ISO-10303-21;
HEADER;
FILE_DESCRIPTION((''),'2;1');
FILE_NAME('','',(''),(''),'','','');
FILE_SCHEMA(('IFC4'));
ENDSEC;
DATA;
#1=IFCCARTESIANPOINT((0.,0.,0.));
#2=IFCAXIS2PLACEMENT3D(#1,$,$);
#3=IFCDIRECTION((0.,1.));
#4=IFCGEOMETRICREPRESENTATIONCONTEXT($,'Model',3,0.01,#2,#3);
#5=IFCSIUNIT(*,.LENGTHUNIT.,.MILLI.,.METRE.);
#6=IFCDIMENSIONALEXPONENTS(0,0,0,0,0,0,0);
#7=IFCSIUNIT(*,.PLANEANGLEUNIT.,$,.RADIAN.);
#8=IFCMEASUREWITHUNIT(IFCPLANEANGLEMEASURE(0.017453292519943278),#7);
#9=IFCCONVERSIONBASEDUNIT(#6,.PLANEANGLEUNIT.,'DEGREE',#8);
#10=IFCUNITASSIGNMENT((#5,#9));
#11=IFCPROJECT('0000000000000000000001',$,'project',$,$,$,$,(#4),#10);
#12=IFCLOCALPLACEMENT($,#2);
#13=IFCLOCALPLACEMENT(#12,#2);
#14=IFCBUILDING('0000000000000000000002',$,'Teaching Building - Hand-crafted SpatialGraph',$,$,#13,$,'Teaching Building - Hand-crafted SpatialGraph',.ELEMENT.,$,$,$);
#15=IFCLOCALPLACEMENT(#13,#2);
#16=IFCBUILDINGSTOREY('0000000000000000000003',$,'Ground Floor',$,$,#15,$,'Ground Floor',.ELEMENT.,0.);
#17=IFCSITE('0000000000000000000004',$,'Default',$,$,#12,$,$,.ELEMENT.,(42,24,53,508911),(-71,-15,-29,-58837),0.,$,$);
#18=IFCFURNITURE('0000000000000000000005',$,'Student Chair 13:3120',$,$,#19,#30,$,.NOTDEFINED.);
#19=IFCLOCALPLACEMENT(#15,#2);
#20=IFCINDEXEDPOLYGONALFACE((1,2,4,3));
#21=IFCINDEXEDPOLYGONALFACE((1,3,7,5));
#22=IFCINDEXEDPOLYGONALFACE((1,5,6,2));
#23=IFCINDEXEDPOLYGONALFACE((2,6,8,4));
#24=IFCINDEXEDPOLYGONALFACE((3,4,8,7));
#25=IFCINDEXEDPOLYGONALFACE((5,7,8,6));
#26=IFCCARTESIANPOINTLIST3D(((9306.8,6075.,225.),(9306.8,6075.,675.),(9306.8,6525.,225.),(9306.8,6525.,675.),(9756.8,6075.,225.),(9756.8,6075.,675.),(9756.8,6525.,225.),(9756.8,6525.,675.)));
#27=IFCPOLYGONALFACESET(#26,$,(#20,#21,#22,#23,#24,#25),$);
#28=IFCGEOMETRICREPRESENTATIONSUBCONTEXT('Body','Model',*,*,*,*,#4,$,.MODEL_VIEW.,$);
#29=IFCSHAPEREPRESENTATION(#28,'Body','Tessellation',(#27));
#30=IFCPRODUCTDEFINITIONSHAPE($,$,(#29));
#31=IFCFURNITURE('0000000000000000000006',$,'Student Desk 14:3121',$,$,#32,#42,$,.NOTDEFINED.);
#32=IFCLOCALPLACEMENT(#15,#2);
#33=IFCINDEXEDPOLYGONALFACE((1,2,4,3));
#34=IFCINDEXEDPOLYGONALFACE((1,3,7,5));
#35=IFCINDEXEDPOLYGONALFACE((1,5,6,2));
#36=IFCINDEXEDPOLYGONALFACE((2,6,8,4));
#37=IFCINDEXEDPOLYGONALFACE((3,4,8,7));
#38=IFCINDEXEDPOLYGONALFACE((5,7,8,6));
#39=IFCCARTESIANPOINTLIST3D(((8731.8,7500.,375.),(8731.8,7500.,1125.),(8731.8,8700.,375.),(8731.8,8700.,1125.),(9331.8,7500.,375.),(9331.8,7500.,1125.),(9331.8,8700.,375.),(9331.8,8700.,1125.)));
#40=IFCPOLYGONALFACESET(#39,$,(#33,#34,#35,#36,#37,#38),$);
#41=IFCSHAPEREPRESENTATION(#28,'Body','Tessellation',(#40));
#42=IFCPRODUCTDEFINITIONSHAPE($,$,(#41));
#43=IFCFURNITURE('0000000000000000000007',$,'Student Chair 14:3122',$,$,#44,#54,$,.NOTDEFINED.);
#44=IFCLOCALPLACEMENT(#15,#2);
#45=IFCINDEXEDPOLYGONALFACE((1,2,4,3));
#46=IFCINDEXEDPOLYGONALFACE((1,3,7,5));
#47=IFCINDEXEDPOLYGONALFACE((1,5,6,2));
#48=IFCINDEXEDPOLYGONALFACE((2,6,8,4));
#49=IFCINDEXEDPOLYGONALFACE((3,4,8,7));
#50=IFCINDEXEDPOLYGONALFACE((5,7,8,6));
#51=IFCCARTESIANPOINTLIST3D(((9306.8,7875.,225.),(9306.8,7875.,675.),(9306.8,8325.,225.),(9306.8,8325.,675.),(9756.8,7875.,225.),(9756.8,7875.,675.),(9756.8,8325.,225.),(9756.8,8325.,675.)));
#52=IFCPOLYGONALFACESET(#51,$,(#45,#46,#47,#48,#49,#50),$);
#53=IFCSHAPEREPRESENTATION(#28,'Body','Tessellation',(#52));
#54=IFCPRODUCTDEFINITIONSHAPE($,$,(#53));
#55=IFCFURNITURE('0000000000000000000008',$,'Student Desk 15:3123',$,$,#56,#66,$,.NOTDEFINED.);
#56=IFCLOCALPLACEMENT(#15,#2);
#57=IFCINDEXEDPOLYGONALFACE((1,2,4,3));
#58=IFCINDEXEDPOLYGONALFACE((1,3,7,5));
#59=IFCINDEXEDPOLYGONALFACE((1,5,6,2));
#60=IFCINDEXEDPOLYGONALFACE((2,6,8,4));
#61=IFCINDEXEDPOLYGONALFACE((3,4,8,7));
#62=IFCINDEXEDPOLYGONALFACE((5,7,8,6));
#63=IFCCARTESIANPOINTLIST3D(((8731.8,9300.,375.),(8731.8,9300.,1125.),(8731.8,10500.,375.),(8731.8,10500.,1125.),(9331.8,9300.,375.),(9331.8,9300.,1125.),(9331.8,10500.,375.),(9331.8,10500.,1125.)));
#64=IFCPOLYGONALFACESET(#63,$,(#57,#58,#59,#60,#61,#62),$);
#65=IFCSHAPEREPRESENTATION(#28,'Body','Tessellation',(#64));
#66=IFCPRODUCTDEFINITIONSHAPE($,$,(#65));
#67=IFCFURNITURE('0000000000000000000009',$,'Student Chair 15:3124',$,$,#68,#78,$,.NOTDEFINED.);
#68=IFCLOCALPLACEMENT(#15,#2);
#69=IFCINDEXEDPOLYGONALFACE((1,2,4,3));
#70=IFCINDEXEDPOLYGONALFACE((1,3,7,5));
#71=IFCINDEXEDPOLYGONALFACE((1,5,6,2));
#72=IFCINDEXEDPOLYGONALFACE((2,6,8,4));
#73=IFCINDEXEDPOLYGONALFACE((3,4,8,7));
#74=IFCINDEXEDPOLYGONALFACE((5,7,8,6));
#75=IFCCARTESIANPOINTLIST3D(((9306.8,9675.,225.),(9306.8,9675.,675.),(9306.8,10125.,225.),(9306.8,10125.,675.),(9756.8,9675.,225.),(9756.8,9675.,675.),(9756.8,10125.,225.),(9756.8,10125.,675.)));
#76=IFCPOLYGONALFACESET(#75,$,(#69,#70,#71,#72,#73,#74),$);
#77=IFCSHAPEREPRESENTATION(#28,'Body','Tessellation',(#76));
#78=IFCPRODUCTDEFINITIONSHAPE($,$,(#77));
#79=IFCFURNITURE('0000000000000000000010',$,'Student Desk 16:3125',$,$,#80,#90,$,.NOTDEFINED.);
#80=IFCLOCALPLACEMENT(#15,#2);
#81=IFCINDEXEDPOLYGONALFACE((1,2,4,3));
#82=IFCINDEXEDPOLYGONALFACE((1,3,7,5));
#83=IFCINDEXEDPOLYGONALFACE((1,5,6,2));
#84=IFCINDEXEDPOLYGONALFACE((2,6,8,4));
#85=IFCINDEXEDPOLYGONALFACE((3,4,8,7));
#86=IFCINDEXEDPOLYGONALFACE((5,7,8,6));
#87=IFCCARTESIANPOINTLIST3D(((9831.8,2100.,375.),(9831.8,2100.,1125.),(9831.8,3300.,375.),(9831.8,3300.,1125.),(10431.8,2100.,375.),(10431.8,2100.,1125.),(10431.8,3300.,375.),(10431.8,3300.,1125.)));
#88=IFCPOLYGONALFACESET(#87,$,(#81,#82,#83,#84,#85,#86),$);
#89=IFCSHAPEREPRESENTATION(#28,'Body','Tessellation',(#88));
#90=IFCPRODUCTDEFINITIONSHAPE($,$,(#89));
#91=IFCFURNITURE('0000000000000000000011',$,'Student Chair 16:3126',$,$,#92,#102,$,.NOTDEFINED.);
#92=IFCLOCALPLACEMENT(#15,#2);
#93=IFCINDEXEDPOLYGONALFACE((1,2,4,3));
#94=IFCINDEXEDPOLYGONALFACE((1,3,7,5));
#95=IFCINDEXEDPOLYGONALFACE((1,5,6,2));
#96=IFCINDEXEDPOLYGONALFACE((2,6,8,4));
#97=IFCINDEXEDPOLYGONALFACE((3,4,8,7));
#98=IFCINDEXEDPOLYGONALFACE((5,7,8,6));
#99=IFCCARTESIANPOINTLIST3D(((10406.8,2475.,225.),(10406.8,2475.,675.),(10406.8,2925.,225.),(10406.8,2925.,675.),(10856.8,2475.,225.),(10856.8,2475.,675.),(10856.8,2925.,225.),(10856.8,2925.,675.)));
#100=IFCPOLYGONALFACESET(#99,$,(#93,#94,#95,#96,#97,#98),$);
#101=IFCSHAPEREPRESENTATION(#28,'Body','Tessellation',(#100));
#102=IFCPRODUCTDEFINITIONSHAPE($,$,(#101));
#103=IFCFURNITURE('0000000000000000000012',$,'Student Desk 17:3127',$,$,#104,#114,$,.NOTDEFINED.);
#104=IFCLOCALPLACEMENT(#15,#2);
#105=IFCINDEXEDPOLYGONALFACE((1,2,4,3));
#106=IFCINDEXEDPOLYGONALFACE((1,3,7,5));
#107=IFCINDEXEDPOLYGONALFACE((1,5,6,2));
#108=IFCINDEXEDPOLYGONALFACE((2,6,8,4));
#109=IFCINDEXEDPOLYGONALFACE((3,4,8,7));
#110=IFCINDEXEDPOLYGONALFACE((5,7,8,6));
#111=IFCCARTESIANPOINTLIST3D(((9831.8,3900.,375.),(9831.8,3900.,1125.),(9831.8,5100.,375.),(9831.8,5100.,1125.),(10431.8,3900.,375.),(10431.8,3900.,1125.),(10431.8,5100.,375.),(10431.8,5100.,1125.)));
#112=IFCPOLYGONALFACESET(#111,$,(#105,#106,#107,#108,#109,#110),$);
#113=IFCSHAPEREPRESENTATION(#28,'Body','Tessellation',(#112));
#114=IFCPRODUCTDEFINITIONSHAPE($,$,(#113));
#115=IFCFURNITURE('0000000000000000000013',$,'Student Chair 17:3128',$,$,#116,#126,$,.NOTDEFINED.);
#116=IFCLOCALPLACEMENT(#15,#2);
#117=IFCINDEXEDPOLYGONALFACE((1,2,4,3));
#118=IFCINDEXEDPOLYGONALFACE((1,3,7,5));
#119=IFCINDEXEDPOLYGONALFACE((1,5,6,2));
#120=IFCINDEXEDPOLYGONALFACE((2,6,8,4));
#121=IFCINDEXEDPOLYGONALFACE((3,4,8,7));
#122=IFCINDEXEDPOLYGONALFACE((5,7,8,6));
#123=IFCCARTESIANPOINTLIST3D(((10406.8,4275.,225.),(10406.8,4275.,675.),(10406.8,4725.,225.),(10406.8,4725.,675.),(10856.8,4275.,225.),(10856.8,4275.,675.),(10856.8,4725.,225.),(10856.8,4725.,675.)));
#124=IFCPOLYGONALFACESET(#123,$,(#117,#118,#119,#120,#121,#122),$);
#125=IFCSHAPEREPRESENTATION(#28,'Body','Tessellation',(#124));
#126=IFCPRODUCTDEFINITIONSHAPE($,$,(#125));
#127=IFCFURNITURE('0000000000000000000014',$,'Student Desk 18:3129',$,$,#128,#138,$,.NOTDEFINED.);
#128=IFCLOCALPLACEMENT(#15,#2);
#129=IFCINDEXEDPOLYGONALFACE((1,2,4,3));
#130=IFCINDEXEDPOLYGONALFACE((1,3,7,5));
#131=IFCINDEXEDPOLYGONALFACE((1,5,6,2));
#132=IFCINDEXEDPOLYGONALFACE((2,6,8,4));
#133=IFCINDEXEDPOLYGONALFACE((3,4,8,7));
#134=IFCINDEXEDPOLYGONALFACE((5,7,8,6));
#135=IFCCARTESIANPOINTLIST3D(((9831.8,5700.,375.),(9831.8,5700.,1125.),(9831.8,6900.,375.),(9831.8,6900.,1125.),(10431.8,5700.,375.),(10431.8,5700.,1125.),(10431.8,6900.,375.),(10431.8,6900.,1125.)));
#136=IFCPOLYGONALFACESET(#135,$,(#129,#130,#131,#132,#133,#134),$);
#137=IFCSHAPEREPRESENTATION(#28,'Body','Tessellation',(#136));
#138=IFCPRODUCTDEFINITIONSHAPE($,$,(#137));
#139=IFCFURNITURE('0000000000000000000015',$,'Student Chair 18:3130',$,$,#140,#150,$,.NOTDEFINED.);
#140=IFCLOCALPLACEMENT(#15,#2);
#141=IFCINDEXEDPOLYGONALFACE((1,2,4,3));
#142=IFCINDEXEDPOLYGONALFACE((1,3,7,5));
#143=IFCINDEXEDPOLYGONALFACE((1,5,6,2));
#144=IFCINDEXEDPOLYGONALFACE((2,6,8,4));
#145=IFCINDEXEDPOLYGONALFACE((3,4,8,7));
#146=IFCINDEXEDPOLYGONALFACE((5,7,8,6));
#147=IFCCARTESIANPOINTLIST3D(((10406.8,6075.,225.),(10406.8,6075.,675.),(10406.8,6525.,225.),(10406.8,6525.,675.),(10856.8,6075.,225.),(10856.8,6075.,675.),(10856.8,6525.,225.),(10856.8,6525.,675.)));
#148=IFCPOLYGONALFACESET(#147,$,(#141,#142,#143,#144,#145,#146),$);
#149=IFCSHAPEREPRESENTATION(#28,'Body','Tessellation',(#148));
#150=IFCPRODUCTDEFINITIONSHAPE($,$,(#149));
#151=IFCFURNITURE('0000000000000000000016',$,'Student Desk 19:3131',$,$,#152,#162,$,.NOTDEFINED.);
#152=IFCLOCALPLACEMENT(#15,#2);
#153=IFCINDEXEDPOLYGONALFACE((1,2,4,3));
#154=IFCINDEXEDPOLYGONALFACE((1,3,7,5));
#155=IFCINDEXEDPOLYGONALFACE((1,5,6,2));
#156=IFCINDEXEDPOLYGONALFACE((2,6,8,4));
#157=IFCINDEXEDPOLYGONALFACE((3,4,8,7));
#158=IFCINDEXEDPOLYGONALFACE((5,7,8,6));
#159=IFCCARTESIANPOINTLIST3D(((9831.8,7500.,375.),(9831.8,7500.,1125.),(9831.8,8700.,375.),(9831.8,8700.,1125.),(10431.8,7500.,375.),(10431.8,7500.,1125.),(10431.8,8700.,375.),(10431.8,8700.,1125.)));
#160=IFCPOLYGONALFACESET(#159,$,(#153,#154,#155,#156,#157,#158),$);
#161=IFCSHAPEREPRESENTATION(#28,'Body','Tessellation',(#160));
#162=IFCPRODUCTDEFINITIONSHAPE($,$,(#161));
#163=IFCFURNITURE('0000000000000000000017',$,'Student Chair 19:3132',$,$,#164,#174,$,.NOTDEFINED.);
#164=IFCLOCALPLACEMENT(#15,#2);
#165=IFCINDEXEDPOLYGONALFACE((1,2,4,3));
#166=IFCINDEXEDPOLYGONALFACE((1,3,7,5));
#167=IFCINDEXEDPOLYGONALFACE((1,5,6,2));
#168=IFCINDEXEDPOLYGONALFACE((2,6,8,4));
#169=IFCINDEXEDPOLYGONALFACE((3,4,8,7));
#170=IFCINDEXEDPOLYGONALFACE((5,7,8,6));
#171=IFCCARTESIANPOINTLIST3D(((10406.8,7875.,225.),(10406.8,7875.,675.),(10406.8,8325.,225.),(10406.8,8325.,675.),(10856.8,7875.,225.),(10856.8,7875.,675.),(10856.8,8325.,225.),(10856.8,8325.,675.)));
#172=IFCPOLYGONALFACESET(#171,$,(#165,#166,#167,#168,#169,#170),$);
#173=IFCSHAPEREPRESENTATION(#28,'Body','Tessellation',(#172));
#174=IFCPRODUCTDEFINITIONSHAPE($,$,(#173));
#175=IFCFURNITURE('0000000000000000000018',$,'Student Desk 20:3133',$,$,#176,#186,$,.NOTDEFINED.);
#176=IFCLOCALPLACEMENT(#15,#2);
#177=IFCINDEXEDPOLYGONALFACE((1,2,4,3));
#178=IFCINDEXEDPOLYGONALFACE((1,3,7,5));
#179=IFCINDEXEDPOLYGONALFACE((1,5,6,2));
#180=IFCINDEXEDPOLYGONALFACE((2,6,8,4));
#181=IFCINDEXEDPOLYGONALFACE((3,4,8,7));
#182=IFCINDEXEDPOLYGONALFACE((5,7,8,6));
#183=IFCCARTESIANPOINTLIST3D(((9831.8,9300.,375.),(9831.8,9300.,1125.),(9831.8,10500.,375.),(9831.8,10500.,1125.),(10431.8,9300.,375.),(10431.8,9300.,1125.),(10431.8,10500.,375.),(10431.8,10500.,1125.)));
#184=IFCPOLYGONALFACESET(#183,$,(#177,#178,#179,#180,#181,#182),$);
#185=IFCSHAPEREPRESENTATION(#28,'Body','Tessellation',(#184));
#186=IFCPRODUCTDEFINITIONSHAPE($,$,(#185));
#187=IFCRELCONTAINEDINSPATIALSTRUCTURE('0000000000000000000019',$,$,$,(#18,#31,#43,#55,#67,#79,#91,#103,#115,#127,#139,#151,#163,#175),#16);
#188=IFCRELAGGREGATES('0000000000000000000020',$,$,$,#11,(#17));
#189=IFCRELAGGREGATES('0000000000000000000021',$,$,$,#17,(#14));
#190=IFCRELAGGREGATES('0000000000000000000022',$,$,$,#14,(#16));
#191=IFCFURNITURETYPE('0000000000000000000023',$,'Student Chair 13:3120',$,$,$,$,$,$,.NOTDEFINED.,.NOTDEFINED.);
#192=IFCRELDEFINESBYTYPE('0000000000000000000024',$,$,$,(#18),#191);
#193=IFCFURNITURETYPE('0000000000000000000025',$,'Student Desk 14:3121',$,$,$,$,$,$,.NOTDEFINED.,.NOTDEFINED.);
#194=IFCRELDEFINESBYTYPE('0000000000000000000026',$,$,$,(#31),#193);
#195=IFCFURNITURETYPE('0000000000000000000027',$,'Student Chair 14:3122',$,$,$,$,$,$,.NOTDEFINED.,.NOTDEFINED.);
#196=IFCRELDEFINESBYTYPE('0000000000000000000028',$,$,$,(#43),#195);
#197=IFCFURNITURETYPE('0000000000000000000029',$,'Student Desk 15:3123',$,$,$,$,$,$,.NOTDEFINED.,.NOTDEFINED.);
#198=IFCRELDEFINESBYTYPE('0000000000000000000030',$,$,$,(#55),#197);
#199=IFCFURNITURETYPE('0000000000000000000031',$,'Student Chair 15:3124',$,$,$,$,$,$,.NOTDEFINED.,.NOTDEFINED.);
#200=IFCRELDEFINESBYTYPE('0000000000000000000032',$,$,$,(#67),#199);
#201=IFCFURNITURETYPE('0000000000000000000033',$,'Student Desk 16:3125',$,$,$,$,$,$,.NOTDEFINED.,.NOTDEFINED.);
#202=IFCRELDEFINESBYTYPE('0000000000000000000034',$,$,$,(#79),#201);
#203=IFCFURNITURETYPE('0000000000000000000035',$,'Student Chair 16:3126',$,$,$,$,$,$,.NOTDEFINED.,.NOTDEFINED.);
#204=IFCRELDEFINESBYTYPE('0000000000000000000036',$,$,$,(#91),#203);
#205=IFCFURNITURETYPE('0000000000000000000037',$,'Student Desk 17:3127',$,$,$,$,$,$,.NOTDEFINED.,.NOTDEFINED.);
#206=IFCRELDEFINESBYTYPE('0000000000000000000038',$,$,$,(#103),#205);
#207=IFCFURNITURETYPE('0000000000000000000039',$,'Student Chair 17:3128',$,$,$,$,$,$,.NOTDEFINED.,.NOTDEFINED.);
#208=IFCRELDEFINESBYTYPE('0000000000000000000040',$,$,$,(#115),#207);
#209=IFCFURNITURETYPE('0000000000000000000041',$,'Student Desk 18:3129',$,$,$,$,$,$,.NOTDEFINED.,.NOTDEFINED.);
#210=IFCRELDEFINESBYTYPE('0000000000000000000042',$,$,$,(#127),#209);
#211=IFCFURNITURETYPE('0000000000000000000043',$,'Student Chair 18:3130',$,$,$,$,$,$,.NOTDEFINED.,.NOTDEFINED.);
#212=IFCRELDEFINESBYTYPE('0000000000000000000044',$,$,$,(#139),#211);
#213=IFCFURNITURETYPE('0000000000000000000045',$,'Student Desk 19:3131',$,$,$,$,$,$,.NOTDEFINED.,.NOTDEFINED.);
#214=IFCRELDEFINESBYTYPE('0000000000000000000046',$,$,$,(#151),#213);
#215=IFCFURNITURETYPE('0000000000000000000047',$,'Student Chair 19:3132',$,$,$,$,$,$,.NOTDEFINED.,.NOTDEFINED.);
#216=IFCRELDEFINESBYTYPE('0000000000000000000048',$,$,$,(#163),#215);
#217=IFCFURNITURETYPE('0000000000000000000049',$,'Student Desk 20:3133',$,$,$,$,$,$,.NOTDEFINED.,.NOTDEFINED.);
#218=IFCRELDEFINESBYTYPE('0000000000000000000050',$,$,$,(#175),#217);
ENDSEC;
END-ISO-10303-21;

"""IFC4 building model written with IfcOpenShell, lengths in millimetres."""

from ifc_helpers import new_model, entity, si_unit, converted_unit, direction, frame, frame_2d, origin, origin_2d_with_axis, place, context, subcontext, project, spatial, rectangle, extrude, type_object, element, save


model = new_model("IFC4")

# Units and contexts
model_context = context("Model", 3, precision=0.01, world=origin(), true_north=direction((0.0, 1.0)))
body_context = subcontext(model_context, "Body", "Model", "MODEL_VIEW")
ifc_project = project(units=[si_unit("LENGTHUNIT", "METRE", prefix="MILLI"), converted_unit("PLANEANGLEUNIT", "DEGREE", entity("IfcPlaneAngleMeasure", 0.017453292519943278), si_unit("PLANEANGLEUNIT", "RADIAN"), dimensions=[0, 0, 0, 0, 0, 0, 0])], contexts=[model_context])

# Site, building, storey
site_placement = place(None, origin())
site = spatial("IfcSite", under=ifc_project, at=site_placement, Name="Default", CompositionType="ELEMENT", RefLatitude=(42, 24, 53, 508911), RefLongitude=(-71, -15, -29, -58837), RefElevation=0.0)
building_placement = place(site_placement, origin())
building = spatial("IfcBuilding", under=site, at=building_placement, Name="Teaching Building - Hand-crafted SpatialGraph", LongName="Teaching Building - Hand-crafted SpatialGraph", CompositionType="ELEMENT")
storey_placement = place(building_placement, origin())
storey = spatial("IfcBuildingStorey", under=building, at=storey_placement, Name="Ground Floor", LongName="Ground Floor", CompositionType="ELEMENT", Elevation=0.0)

# Furniture
furniture_type_1 = type_object("IfcFurnitureType", Name="Student Chair 13:3120", PredefinedType="NOTDEFINED")
furniture_1_placement = place(storey_placement, origin())
element("IfcFurniture", 1, at=furniture_1_placement, inside=storey, type_object=furniture_type_1, Name="Student Chair 13:3120", PredefinedType="NOTDEFINED", context=body_context, shape_type="SweptSolid", body=[
    extrude(rectangle(XDim=450.0, YDim=450.0, at=origin_2d_with_axis()), frame((9531.8, 6300.0, 225.0)), (0.0, 0.0, 1.0), 450.0),
])
furniture_type_2 = type_object("IfcFurnitureType", Name="Student Desk 14:3121", PredefinedType="NOTDEFINED")
furniture_2_placement = place(storey_placement, origin())
element("IfcFurniture", 2, at=furniture_2_placement, inside=storey, type_object=furniture_type_2, Name="Student Desk 14:3121", PredefinedType="NOTDEFINED", context=body_context, shape_type="SweptSolid", body=[
    extrude(rectangle(XDim=1200.0, YDim=600.0, at=origin_2d_with_axis()), frame((9031.8, 8100.0, 375.0), z_axis=(0.0, 0.0, 1.0), x_axis=(0.0, 1.0, 0.0)), (0.0, 0.0, 1.0), 750.0),
])
furniture_type_3 = type_object("IfcFurnitureType", Name="Student Chair 14:3122", PredefinedType="NOTDEFINED")
furniture_3_placement = place(storey_placement, origin())
element("IfcFurniture", 3, at=furniture_3_placement, inside=storey, type_object=furniture_type_3, Name="Student Chair 14:3122", PredefinedType="NOTDEFINED", context=body_context, shape_type="SweptSolid", body=[
    extrude(rectangle(XDim=450.0, YDim=450.0, at=origin_2d_with_axis()), frame((9531.8, 8100.0, 225.0)), (0.0, 0.0, 1.0), 450.0),
])
furniture_type_4 = type_object("IfcFurnitureType", Name="Student Desk 15:3123", PredefinedType="NOTDEFINED")
furniture_4_placement = place(storey_placement, origin())
element("IfcFurniture", 4, at=furniture_4_placement, inside=storey, type_object=furniture_type_4, Name="Student Desk 15:3123", PredefinedType="NOTDEFINED", context=body_context, shape_type="SweptSolid", body=[
    extrude(rectangle(XDim=1200.0, YDim=600.0, at=origin_2d_with_axis()), frame((9031.8, 9900.0, 375.0), z_axis=(0.0, 0.0, 1.0), x_axis=(0.0, 1.0, 0.0)), (0.0, 0.0, 1.0), 750.0),
])
furniture_type_5 = type_object("IfcFurnitureType", Name="Student Chair 15:3124", PredefinedType="NOTDEFINED")
furniture_5_placement = place(storey_placement, origin())
element("IfcFurniture", 5, at=furniture_5_placement, inside=storey, type_object=furniture_type_5, Name="Student Chair 15:3124", PredefinedType="NOTDEFINED", context=body_context, shape_type="SweptSolid", body=[
    extrude(rectangle(XDim=450.0, YDim=450.0, at=frame_2d((0.0, 0.0), x_axis=(1.0, 0.0))), frame((9531.8, 9900.0, 225.0)), (0.0, 0.0, 1.0), 450.0),
])
furniture_type_6 = type_object("IfcFurnitureType", Name="Student Desk 16:3125", PredefinedType="NOTDEFINED")
furniture_6_placement = place(storey_placement, origin())
element("IfcFurniture", 6, at=furniture_6_placement, inside=storey, type_object=furniture_type_6, Name="Student Desk 16:3125", PredefinedType="NOTDEFINED", context=body_context, shape_type="SweptSolid", body=[
    extrude(rectangle(XDim=1200.0, YDim=600.0, at=origin_2d_with_axis()), frame((10131.8, 2700.0, 375.0), z_axis=(0.0, 0.0, 1.0), x_axis=(0.0, 1.0, 0.0)), (0.0, 0.0, 1.0), 750.0),
])
furniture_type_7 = type_object("IfcFurnitureType", Name="Student Chair 16:3126", PredefinedType="NOTDEFINED")
furniture_7_placement = place(storey_placement, origin())
element("IfcFurniture", 7, at=furniture_7_placement, inside=storey, type_object=furniture_type_7, Name="Student Chair 16:3126", PredefinedType="NOTDEFINED", context=body_context, shape_type="SweptSolid", body=[
    extrude(rectangle(XDim=450.0, YDim=450.0, at=origin_2d_with_axis()), frame((10631.8, 2700.0, 225.0)), (0.0, 0.0, 1.0), 450.0),
])
furniture_type_8 = type_object("IfcFurnitureType", Name="Student Desk 17:3127", PredefinedType="NOTDEFINED")
furniture_8_placement = place(storey_placement, origin())
element("IfcFurniture", 8, at=furniture_8_placement, inside=storey, type_object=furniture_type_8, Name="Student Desk 17:3127", PredefinedType="NOTDEFINED", context=body_context, shape_type="SweptSolid", body=[
    extrude(rectangle(XDim=1200.0, YDim=600.0, at=frame_2d((0.0, 0.0), x_axis=(1.0, 0.0))), frame((10131.8, 4500.0, 375.0), z_axis=(0.0, 0.0, 1.0), x_axis=(0.0, 1.0, 0.0)), (0.0, 0.0, 1.0), 750.0),
])
furniture_type_9 = type_object("IfcFurnitureType", Name="Student Chair 17:3128", PredefinedType="NOTDEFINED")
furniture_9_placement = place(storey_placement, origin())
element("IfcFurniture", 9, at=furniture_9_placement, inside=storey, type_object=furniture_type_9, Name="Student Chair 17:3128", PredefinedType="NOTDEFINED", context=body_context, shape_type="SweptSolid", body=[
    extrude(rectangle(XDim=450.0, YDim=450.0, at=origin_2d_with_axis()), frame((10631.8, 4500.0, 225.0)), (0.0, 0.0, 1.0), 450.0),
])
furniture_type_10 = type_object("IfcFurnitureType", Name="Student Desk 18:3129", PredefinedType="NOTDEFINED")
furniture_10_placement = place(storey_placement, origin())
element("IfcFurniture", 10, at=furniture_10_placement, inside=storey, type_object=furniture_type_10, Name="Student Desk 18:3129", PredefinedType="NOTDEFINED", context=body_context, shape_type="SweptSolid", body=[
    extrude(rectangle(XDim=1200.0, YDim=600.0, at=origin_2d_with_axis()), frame((10131.8, 6300.0, 375.0), z_axis=(0.0, 0.0, 1.0), x_axis=(0.0, 1.0, 0.0)), (0.0, 0.0, 1.0), 750.0),
])
furniture_type_11 = type_object("IfcFurnitureType", Name="Student Chair 18:3130", PredefinedType="NOTDEFINED")
furniture_11_placement = place(storey_placement, origin())
element("IfcFurniture", 11, at=furniture_11_placement, inside=storey, type_object=furniture_type_11, Name="Student Chair 18:3130", PredefinedType="NOTDEFINED", context=body_context, shape_type="SweptSolid", body=[
    extrude(rectangle(XDim=450.0, YDim=450.0, at=origin_2d_with_axis()), frame((10631.8, 6300.0, 225.0)), (0.0, 0.0, 1.0), 450.0),
])
furniture_type_12 = type_object("IfcFurnitureType", Name="Student Desk 19:3131", PredefinedType="NOTDEFINED")
furniture_12_placement = place(storey_placement, origin())
element("IfcFurniture", 12, at=furniture_12_placement, inside=storey, type_object=furniture_type_12, Name="Student Desk 19:3131", PredefinedType="NOTDEFINED", context=body_context, shape_type="SweptSolid", body=[
    extrude(rectangle(XDim=1200.0, YDim=600.0, at=origin_2d_with_axis()), frame((10131.8, 8100.0, 375.0), z_axis=(0.0, 0.0, 1.0), x_axis=(0.0, 1.0, 0.0)), (0.0, 0.0, 1.0), 750.0),
])
furniture_type_13 = type_object("IfcFurnitureType", Name="Student Chair 19:3132", PredefinedType="NOTDEFINED")
furniture_13_placement = place(storey_placement, origin())
element("IfcFurniture", 13, at=furniture_13_placement, inside=storey, type_object=furniture_type_13, Name="Student Chair 19:3132", PredefinedType="NOTDEFINED", context=body_context, shape_type="SweptSolid", body=[
    extrude(rectangle(XDim=450.0, YDim=450.0, at=origin_2d_with_axis()), frame((10631.8, 8100.0, 225.0)), (0.0, 0.0, 1.0), 450.0),
])
furniture_type_14 = type_object("IfcFurnitureType", Name="Student Desk 20:3133", PredefinedType="NOTDEFINED")
furniture_14_placement = place(storey_placement, origin())
element("IfcFurniture", 14, at=furniture_14_placement, inside=storey, type_object=furniture_type_14, Name="Student Desk 20:3133", PredefinedType="NOTDEFINED", context=body_context, shape_type="SweptSolid", body=[
    extrude(rectangle(XDim=1200.0, YDim=600.0, at=origin_2d_with_axis()), frame((10131.8, 9900.0, 375.0), z_axis=(0.0, 0.0, 1.0), x_axis=(0.0, 1.0, 0.0)), (0.0, 0.0, 1.0), 750.0),
])

save(model, "model.ifc")
